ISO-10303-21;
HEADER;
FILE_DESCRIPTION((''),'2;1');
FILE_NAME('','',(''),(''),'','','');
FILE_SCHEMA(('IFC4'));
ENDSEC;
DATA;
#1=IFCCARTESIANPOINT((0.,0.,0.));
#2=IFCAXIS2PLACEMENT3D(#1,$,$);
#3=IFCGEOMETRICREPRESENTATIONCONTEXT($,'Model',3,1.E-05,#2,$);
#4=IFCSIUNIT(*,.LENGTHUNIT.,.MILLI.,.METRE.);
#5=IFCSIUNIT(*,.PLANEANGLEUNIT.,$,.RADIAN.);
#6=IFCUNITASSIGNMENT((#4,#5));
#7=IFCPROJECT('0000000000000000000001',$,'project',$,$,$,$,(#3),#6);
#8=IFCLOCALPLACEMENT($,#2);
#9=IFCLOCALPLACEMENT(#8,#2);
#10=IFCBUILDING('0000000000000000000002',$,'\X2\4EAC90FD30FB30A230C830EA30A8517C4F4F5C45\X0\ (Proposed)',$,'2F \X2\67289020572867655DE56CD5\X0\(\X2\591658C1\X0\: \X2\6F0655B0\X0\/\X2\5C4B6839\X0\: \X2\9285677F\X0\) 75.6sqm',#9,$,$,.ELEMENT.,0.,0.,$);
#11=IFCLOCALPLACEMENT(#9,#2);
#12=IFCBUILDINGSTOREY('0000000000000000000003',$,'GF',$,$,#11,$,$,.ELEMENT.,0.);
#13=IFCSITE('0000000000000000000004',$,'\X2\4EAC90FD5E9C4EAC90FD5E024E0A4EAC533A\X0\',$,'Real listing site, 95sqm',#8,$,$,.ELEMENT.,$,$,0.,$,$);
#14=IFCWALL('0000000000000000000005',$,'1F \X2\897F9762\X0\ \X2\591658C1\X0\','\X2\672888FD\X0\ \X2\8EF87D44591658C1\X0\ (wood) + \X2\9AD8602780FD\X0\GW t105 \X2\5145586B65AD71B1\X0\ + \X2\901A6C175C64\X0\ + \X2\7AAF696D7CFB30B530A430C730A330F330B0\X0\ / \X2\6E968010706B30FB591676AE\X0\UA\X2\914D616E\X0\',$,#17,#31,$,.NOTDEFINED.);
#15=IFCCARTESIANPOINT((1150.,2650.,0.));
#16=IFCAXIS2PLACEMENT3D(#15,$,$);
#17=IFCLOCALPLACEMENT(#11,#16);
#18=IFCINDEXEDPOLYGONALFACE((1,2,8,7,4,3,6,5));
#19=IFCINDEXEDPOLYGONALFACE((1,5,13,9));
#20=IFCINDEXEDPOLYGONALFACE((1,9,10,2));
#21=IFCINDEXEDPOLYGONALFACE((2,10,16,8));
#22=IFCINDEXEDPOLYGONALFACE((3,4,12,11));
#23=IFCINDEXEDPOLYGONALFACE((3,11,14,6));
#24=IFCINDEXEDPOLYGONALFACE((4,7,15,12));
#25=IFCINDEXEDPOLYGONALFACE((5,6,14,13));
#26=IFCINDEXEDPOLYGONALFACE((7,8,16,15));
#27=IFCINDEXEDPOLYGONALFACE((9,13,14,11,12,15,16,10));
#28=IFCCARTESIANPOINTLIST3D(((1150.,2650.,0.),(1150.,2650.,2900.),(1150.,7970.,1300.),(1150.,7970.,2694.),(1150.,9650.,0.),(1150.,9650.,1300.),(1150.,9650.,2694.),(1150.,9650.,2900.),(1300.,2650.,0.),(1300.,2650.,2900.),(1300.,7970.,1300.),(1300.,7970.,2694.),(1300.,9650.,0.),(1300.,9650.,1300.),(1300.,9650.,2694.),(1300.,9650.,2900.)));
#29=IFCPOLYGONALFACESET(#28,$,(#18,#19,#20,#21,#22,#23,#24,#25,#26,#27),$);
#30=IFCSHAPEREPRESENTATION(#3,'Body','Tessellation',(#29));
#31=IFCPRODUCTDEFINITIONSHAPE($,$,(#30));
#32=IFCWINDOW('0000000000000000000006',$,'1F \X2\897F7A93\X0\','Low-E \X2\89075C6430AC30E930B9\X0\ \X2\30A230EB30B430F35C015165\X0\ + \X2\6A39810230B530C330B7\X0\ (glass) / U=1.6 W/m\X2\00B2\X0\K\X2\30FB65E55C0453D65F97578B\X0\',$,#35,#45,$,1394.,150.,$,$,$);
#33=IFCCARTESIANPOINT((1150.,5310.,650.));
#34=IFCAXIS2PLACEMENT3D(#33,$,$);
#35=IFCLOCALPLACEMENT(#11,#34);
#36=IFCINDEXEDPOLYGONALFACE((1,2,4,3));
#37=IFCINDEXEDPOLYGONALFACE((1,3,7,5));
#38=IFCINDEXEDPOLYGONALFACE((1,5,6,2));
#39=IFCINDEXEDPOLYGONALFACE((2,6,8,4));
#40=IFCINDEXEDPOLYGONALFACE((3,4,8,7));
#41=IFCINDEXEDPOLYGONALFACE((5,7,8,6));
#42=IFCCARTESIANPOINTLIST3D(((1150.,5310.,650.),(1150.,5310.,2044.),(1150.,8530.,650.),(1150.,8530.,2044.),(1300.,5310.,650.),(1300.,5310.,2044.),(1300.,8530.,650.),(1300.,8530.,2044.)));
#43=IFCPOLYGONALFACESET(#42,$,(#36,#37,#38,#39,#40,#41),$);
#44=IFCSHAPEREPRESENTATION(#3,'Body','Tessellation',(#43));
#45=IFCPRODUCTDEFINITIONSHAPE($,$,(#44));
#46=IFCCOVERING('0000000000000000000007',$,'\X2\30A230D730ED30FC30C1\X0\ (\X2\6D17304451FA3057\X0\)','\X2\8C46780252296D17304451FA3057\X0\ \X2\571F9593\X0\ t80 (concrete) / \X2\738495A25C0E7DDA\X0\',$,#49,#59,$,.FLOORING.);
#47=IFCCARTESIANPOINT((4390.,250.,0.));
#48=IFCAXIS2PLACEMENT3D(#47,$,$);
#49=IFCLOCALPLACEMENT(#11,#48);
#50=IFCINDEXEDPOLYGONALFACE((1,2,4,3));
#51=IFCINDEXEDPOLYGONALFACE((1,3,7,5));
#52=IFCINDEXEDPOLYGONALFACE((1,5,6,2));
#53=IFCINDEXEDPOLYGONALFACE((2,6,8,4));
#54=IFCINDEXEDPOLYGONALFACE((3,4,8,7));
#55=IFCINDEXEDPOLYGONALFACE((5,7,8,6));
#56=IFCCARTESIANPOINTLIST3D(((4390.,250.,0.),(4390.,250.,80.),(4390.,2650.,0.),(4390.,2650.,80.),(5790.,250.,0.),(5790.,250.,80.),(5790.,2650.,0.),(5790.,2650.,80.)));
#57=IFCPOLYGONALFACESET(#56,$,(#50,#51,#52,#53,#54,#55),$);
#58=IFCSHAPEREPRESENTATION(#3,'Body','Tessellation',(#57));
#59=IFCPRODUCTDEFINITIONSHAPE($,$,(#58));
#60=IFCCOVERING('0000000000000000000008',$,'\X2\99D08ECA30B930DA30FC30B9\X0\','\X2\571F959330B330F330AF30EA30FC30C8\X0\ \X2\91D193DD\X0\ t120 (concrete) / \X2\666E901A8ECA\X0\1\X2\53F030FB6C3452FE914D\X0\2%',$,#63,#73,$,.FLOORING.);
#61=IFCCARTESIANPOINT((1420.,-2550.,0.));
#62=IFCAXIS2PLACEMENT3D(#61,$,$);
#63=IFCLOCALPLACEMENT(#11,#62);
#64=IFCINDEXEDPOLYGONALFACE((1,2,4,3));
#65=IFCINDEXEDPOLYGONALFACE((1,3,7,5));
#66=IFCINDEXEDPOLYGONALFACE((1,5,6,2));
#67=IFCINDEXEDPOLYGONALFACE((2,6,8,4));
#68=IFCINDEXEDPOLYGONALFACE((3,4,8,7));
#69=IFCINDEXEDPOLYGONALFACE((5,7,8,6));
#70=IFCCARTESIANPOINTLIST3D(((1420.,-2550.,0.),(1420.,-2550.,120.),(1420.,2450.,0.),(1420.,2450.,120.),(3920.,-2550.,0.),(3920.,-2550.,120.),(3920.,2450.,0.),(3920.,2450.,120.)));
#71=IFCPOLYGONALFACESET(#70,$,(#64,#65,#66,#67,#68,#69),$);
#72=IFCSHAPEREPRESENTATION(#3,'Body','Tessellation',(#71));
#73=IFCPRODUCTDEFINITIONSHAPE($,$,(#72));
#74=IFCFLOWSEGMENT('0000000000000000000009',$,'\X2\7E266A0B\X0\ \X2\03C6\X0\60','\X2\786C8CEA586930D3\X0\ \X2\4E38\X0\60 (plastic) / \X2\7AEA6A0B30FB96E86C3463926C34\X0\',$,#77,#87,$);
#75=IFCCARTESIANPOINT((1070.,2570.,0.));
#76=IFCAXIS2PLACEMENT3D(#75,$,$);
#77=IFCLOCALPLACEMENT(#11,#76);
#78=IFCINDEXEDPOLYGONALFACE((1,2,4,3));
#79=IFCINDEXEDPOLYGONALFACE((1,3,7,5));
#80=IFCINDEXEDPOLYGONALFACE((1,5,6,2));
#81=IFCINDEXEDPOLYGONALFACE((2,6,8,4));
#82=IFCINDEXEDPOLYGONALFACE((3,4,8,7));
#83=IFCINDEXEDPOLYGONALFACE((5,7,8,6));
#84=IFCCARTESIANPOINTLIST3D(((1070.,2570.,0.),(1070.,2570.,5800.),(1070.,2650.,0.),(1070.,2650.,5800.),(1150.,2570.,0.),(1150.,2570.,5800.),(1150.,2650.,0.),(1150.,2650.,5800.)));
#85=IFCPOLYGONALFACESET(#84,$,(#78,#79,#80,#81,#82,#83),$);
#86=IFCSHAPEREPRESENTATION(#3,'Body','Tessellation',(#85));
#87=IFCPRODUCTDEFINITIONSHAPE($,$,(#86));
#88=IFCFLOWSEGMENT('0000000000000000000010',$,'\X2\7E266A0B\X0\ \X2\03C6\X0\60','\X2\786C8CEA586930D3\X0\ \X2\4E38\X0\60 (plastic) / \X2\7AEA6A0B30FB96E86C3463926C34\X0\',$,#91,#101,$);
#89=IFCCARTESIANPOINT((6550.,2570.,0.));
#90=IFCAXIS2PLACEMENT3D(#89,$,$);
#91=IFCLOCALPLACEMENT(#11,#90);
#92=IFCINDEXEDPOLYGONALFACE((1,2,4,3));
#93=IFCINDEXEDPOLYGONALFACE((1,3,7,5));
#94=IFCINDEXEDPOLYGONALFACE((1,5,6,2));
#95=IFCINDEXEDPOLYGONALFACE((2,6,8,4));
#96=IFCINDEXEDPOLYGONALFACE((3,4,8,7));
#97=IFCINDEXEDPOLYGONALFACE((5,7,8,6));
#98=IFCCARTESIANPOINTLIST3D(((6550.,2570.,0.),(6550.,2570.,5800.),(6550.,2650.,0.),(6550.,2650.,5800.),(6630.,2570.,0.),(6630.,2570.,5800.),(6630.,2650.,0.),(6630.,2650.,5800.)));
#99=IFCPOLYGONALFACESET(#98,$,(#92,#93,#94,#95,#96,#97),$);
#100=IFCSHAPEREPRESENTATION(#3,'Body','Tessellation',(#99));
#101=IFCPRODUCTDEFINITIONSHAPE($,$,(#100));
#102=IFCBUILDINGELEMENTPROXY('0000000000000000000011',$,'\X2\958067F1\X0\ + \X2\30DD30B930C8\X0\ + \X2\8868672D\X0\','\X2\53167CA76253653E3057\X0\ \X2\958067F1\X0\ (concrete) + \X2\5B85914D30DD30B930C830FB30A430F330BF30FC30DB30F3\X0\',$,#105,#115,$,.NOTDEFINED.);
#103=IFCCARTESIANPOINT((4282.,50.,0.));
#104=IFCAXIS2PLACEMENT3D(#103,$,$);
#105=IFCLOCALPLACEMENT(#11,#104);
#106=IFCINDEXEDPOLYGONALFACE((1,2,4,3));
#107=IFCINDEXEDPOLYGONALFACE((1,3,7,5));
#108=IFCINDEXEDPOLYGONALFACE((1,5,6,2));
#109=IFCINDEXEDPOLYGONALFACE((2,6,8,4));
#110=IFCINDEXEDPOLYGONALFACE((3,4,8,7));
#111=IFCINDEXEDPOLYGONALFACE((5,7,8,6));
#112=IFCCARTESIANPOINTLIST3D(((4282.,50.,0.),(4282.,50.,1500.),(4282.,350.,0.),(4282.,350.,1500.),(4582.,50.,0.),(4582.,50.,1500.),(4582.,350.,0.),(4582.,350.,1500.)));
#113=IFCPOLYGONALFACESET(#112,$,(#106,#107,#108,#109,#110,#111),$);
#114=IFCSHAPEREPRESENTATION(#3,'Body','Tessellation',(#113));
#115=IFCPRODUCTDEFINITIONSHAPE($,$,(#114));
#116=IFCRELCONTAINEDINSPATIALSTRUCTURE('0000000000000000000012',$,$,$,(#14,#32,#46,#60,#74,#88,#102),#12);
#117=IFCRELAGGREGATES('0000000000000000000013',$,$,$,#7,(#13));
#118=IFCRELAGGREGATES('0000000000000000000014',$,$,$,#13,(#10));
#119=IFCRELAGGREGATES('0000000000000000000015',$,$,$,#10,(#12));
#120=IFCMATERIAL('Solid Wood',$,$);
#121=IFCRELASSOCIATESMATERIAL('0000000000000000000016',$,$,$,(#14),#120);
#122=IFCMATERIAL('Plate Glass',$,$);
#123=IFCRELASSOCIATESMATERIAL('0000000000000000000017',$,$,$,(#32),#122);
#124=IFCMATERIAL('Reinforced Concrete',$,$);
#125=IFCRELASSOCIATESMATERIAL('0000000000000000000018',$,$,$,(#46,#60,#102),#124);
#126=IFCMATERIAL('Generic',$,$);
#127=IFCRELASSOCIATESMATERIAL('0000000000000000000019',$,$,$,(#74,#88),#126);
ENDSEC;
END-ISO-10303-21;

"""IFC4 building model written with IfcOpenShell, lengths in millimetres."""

from ifc_helpers import new_model, si_unit, frame, frame_2d, origin, place, context, project, spatial, rectangle, extrude, material, element, fill, save


model = new_model("IFC4")

# Units and contexts
model_context = context("Model", 3, precision=1e-05, world=origin())
ifc_project = project(units=[si_unit("LENGTHUNIT", "METRE", prefix="MILLI"), si_unit("PLANEANGLEUNIT", "RADIAN")], contexts=[model_context])

# Site, building, storey
site_placement = place(None, origin())
site = spatial("IfcSite", under=ifc_project, at=site_placement, Name="京都府京都市上京区", ObjectType="Real listing site, 95sqm", CompositionType="ELEMENT", RefElevation=0.0)
building_placement = place(site_placement, origin())
building = spatial("IfcBuilding", under=site, at=building_placement, Name="京都・アトリエ兼住居 (Proposed)", ObjectType="2F 木造在来工法(外壁: 漆喰/屋根: 銅板) 75.6sqm", CompositionType="ELEMENT", ElevationOfRefHeight=0.0, ElevationOfTerrain=0.0)
storey_placement = place(building_placement, origin())
storey = spatial("IfcBuildingStorey", under=building, at=storey_placement, Name="GF", CompositionType="ELEMENT", Elevation=0.0)

# Shared definitions
ifc_material_1 = material(Name="Solid Wood")

# Shared definitions
ifc_material_2 = material(Name="Reinforced Concrete")

# Shared definitions
ifc_material_3 = material(Name="Plate Glass")

# Wall, opening, window
wall_1_placement = place(storey_placement, frame((1150.0, 2650.0, 0.0)))
wall_1 = element("IfcWall", 1, at=wall_1_placement, inside=storey, material=ifc_material_1, Name="1F 西面 外壁", Description="木製 軸組外壁 (wood) + 高性能GW t105 充填断熱 + 通気層 + 窯業系サイディング / 準耐火・外皮UA配慮", PredefinedType="NOTDEFINED", context=model_context, shape_type="SweptSolid", body=[
    extrude(rectangle(XDim=150.0, YDim=7000.0, at=frame_2d((75.0, 3500.0))), frame((1150.0, 2650.0, 0.0)), (0.0, 0.0, 1.0), 2900.0),
])
opening_1_placement = place(storey_placement, frame((1150.0, 5310.0, 650.0)))
opening_1 = element("IfcOpeningElement", 2, at=opening_1_placement, cuts=wall_1, PredefinedType="NOTDEFINED", context=model_context, shape_type="SweptSolid", body=[
    extrude(rectangle(XDim=150.0, YDim=3220.0, at=frame_2d((75.0, 1610.0))), frame((1150.0, 5310.0, 650.0)), (0.0, 0.0, 1.0), 1394.0),
])
window_1_placement = place(storey_placement, frame((1150.0, 5310.0, 650.0)))
window_1 = element("IfcWindow", 3, at=window_1_placement, inside=storey, material=ifc_material_3, Name="1F 西窓", Description="Low-E 複層ガラス アルゴン封入 + 樹脂サッシ (glass) / U=1.6 W/m²K・日射取得型", OverallHeight=1394.0, OverallWidth=150.0, context=model_context, shape_type="SweptSolid", body=[
    extrude(rectangle(XDim=150.0, YDim=3220.0, at=frame_2d((75.0, 1610.0))), frame((1150.0, 5310.0, 650.0)), (0.0, 0.0, 1.0), 1394.0),
])
fill(opening_1, window_1)

# Coverings
covering_1_placement = place(storey_placement, frame((4390.0, 250.0, 0.0)))
element("IfcCovering", 4, at=covering_1_placement, inside=storey, material=ifc_material_2, Name="アプローチ (洗い出し)", Description="豆砂利洗い出し 土間 t80 (concrete) / 玄関導線", PredefinedType="FLOORING", context=model_context, shape_type="SweptSolid", body=[
    extrude(rectangle(XDim=1400.0, YDim=2400.0, at=frame_2d((700.0, 1200.0))), frame((4390.0, 250.0, 0.0)), (0.0, 0.0, 1.0), 80.0),
])
covering_2_placement = place(storey_placement, frame((1420.0, -2550.0, 0.0)))
element("IfcCovering", 5, at=covering_2_placement, inside=storey, material=ifc_material_2, Name="駐車スペース", Description="土間コンクリート 金鏝 t120 (concrete) / 普通車1台・水勾配2%", PredefinedType="FLOORING", context=model_context, shape_type="SweptSolid", body=[
    extrude(rectangle(XDim=2500.0, YDim=5000.0, at=frame_2d((1250.0, 2500.0))), frame((1420.0, -2550.0, 0.0)), (0.0, 0.0, 1.0), 120.0),
])

# Flow segments
ifc_material_4 = material(Name="Generic")
flow_segment_1_placement = place(storey_placement, frame((1070.0, 2570.0, 0.0)))
element("IfcFlowSegment", 6, at=flow_segment_1_placement, inside=storey, material=ifc_material_4, Name="縦樋 φ60", Description="硬質塩ビ 丸60 (plastic) / 竪樋・雨水排水", context=model_context, shape_type="SweptSolid", body=[
    extrude(rectangle(XDim=80.0, YDim=80.0, at=frame_2d((40.0, 40.0))), frame((1070.0, 2570.0, 0.0)), (0.0, 0.0, 1.0), 5800.0),
])
flow_segment_2_placement = place(storey_placement, frame((6550.0, 2570.0, 0.0)))
element("IfcFlowSegment", 7, at=flow_segment_2_placement, inside=storey, material=ifc_material_4, Name="縦樋 φ60", Description="硬質塩ビ 丸60 (plastic) / 竪樋・雨水排水", context=model_context, shape_type="SweptSolid", body=[
    extrude(rectangle(XDim=80.0, YDim=80.0, at=frame_2d((40.0, 40.0))), frame((6550.0, 2570.0, 0.0)), (0.0, 0.0, 1.0), 5800.0),
])

# Building element proxy
proxy_placement = place(storey_placement, frame((4282.0, 50.0, 0.0)))
element("IfcBuildingElementProxy", 8, at=proxy_placement, inside=storey, material=ifc_material_2, Name="門柱 + ポスト + 表札", Description="化粧打放し 門柱 (concrete) + 宅配ポスト・インターホン", PredefinedType="NOTDEFINED", context=model_context, shape_type="SweptSolid", body=[
    extrude(rectangle(XDim=300.0, YDim=300.0, at=frame_2d((150.0, 150.0))), frame((4282.0, 50.0, 0.0)), (0.0, 0.0, 1.0), 1500.0),
])

save(model, "model.ifc")
